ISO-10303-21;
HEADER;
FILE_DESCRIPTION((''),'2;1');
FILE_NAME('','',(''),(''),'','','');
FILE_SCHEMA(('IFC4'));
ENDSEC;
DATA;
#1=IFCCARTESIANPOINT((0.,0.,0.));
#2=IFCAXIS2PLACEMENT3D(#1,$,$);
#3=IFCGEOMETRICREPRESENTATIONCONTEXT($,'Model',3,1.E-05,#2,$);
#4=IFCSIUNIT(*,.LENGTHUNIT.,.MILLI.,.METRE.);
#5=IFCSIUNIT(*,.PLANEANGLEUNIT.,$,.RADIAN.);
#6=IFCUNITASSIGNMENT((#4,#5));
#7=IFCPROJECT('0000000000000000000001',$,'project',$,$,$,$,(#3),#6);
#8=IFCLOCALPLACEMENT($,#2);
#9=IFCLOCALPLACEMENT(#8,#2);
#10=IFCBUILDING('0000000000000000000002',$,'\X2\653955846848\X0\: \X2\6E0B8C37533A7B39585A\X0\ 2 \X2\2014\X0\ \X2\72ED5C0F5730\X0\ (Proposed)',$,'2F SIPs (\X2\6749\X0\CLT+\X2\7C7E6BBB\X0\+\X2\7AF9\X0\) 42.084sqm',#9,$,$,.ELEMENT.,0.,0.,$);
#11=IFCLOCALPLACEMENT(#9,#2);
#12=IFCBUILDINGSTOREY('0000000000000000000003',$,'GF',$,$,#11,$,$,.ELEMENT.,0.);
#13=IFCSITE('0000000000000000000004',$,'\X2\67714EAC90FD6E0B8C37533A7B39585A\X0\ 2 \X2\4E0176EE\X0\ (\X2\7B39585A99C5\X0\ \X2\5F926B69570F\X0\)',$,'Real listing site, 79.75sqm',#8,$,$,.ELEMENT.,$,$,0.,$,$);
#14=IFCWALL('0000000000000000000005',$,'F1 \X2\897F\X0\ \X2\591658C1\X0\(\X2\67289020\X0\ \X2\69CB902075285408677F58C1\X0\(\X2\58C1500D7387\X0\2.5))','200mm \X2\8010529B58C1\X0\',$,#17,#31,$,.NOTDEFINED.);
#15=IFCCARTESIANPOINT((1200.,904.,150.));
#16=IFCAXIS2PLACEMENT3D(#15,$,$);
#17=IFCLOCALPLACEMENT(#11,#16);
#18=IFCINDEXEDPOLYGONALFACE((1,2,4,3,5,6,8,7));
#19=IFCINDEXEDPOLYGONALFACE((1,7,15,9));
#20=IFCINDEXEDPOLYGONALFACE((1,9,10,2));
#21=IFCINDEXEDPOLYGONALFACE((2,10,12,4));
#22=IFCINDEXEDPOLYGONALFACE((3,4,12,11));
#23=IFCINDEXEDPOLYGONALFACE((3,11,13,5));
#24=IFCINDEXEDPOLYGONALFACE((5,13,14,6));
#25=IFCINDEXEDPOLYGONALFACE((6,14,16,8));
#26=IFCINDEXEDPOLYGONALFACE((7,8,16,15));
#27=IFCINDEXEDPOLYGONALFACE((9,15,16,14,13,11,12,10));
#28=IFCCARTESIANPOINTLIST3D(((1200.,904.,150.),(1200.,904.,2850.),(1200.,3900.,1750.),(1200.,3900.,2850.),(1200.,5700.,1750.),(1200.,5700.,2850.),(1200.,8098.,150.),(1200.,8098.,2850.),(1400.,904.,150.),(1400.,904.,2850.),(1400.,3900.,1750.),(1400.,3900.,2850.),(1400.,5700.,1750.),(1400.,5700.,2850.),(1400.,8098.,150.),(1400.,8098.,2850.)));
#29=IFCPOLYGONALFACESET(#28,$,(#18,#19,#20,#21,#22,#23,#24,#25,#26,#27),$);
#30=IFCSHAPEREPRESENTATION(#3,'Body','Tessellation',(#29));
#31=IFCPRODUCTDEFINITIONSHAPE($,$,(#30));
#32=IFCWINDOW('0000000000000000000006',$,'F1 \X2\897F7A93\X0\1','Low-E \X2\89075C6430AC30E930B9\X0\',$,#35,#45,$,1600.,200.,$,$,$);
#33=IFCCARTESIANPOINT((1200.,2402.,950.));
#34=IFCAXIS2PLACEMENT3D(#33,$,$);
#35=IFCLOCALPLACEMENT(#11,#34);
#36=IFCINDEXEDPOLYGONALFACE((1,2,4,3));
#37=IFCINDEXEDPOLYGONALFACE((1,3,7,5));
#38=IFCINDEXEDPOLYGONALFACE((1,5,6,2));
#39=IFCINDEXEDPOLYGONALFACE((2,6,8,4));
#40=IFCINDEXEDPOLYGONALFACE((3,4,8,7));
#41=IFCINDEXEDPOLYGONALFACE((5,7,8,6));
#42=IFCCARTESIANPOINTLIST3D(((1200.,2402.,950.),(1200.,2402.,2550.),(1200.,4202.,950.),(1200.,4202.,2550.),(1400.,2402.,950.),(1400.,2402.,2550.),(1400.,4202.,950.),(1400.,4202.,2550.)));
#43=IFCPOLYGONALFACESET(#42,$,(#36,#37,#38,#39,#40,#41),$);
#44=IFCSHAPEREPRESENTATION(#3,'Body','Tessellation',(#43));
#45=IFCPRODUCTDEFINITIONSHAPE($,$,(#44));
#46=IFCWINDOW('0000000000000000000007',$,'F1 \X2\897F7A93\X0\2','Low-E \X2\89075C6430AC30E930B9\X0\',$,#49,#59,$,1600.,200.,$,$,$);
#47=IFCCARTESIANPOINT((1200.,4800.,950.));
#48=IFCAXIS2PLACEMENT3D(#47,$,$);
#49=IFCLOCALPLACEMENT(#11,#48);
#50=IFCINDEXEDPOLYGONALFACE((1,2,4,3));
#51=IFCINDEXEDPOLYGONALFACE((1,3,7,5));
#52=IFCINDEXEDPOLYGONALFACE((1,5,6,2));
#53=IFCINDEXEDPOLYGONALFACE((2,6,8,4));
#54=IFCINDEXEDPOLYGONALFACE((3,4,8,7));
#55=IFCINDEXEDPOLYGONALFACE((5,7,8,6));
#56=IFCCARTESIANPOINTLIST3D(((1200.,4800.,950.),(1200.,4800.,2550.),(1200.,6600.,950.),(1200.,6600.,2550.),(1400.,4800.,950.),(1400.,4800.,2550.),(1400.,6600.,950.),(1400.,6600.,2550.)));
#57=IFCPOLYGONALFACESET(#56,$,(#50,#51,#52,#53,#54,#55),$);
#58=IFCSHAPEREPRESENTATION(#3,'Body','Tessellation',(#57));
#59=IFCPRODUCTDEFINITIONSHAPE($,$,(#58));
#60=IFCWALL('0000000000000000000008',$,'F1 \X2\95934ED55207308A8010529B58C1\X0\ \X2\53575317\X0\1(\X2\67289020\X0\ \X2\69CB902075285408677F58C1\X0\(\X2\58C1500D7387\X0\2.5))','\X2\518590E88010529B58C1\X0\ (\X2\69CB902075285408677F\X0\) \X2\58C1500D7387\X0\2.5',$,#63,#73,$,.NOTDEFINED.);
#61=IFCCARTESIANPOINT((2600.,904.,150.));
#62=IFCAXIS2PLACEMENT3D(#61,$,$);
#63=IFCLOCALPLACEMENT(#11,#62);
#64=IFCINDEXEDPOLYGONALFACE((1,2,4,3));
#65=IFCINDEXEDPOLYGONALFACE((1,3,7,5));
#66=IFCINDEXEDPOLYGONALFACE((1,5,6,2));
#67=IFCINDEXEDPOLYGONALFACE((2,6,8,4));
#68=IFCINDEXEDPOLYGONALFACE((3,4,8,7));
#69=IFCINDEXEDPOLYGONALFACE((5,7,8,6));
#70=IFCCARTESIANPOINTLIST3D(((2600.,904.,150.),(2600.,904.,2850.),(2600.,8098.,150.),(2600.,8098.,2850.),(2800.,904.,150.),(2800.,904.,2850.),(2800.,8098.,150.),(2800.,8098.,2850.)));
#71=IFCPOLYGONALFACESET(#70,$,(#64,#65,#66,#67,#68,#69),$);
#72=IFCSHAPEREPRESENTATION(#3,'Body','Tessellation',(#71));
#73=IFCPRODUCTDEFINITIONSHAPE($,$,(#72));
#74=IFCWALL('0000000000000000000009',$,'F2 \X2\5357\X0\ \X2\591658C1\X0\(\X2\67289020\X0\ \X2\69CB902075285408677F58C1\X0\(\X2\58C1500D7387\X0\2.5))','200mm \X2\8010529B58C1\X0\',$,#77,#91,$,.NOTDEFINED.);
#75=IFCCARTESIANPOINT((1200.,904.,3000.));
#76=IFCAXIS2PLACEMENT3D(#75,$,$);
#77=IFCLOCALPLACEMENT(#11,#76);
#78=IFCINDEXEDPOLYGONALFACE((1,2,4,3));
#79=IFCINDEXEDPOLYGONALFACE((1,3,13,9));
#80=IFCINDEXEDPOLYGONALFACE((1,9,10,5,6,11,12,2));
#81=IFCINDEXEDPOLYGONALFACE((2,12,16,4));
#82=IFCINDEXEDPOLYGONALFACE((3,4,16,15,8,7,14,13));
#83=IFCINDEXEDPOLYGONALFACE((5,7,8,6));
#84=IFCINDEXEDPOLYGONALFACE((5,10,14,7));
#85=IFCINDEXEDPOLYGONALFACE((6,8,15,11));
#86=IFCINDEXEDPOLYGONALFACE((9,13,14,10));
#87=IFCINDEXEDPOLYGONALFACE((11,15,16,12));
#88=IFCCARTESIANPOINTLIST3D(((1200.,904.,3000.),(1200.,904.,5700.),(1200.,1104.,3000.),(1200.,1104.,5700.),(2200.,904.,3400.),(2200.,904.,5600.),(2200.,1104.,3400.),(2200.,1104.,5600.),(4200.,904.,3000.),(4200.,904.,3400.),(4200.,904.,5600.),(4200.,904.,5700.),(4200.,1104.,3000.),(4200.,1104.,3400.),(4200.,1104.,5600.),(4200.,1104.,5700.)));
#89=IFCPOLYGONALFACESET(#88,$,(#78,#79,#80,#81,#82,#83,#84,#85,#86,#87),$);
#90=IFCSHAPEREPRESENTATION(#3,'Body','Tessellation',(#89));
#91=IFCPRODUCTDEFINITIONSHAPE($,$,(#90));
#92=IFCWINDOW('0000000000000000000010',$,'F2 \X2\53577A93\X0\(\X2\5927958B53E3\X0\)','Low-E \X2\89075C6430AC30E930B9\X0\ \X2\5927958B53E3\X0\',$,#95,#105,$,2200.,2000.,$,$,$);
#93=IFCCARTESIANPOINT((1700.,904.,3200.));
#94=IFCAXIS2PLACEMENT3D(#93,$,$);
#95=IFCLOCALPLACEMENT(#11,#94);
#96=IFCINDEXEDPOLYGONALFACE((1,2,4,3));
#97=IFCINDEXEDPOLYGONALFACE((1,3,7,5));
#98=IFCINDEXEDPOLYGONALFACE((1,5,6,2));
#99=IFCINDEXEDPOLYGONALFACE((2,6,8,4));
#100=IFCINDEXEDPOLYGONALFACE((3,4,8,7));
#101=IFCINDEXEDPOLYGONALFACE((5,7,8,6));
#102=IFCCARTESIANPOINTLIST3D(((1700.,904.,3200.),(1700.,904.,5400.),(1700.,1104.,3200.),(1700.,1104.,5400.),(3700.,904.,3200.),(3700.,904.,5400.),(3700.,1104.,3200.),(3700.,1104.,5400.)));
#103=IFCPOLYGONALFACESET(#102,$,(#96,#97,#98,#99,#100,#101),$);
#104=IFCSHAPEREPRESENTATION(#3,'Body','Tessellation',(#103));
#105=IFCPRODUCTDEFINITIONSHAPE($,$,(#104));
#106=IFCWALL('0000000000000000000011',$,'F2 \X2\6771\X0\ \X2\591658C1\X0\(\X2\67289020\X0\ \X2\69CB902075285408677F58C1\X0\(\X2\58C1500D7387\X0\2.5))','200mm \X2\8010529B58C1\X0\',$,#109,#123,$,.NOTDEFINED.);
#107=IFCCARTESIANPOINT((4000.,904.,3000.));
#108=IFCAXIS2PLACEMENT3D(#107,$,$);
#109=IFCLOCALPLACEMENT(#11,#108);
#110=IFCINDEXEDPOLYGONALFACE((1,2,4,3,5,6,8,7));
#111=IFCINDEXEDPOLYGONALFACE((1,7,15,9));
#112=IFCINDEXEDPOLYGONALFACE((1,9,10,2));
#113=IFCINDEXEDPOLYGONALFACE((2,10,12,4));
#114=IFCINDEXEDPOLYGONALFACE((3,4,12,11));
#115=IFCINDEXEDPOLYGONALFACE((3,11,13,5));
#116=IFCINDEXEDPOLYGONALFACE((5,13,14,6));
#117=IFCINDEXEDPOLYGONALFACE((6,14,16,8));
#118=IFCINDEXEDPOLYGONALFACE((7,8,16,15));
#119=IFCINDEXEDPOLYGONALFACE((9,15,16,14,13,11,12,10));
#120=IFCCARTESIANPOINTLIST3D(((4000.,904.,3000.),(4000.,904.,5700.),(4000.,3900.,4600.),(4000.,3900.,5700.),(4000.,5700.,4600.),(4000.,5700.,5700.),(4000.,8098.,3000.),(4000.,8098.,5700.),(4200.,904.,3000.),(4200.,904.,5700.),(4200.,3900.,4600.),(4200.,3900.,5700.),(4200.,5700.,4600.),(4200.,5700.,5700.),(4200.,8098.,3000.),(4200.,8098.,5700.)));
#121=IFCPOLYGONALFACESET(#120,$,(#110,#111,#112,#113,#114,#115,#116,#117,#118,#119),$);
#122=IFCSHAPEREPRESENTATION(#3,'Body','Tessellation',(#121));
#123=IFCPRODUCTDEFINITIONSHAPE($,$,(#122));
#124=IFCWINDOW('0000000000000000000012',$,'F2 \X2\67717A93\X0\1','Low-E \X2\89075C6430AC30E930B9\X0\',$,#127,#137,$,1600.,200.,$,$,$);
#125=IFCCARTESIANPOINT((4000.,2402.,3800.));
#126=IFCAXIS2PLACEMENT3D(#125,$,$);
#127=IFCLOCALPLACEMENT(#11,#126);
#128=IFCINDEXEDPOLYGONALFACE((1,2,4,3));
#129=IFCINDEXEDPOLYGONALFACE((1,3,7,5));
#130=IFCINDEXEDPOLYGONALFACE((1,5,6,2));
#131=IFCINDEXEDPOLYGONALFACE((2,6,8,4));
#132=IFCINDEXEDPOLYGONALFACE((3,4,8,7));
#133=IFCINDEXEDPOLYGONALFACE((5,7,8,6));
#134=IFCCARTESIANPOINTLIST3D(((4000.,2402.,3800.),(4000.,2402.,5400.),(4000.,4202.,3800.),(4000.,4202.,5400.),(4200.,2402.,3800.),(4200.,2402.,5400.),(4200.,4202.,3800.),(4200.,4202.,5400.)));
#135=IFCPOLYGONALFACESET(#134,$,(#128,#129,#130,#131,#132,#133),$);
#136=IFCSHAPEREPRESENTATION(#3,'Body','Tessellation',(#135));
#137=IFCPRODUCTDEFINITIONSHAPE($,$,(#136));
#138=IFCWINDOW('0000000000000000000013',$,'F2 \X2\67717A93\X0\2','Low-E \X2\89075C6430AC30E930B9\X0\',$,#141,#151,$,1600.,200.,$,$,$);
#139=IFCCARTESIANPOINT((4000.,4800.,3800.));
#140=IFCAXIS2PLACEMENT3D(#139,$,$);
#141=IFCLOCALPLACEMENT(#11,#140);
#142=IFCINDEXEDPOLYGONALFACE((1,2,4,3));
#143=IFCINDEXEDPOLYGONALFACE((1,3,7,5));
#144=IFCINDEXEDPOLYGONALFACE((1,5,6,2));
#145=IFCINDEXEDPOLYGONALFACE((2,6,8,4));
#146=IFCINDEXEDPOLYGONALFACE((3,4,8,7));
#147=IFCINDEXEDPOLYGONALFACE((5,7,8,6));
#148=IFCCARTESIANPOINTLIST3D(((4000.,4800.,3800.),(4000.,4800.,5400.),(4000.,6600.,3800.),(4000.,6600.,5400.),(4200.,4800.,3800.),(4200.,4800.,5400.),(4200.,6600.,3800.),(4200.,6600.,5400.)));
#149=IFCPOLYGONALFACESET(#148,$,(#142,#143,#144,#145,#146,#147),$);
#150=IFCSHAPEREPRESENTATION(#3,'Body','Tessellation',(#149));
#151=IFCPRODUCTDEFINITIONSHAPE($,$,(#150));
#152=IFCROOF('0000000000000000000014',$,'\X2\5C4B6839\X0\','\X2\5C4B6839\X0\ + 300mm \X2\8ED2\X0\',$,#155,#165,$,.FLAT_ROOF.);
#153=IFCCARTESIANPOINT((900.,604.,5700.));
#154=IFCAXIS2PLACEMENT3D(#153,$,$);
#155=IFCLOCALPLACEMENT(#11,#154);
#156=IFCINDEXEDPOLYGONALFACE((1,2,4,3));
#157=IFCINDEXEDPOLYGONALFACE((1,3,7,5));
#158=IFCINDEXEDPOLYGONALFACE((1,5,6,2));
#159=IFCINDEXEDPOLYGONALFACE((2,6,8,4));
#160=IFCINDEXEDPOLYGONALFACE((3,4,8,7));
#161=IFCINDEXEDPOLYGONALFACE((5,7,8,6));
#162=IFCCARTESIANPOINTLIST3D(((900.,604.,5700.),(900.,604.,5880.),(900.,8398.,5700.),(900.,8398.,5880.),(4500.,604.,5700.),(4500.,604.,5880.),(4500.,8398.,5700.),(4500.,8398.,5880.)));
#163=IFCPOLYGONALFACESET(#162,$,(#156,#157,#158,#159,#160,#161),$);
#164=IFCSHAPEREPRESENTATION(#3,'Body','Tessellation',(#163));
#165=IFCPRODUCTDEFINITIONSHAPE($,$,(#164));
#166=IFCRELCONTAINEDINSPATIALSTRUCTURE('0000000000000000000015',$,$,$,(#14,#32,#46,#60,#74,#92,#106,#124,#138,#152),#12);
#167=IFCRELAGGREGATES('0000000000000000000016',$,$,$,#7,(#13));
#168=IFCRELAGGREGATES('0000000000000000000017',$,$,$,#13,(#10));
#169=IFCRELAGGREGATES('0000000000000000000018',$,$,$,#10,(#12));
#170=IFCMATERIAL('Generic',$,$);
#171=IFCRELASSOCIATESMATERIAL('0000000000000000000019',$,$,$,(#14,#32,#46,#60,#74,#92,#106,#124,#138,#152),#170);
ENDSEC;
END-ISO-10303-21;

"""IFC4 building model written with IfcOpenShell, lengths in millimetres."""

from ifc_helpers import new_model, si_unit, frame, frame_2d, origin, place, context, project, spatial, rectangle, extrude, material, element, fill, save


model = new_model("IFC4")

# Units and contexts
model_context = context("Model", 3, precision=1e-05, world=origin())
ifc_project = project(units=[si_unit("LENGTHUNIT", "METRE", prefix="MILLI"), si_unit("PLANEANGLEUNIT", "RADIAN")], contexts=[model_context])

# Site, building, storey
site_placement = place(None, origin())
site = spatial("IfcSite", under=ifc_project, at=site_placement, Name="東京都渋谷区笹塚 2 丁目 (笹塚駅 徒歩圏)", ObjectType="Real listing site, 79.75sqm", CompositionType="ELEMENT", RefElevation=0.0)
building_placement = place(site_placement, origin())
building = spatial("IfcBuilding", under=site, at=building_placement, Name="改善案: 渋谷区笹塚 2 — 狭小地 (Proposed)", ObjectType="2F SIPs (杉CLT+籾殻+竹) 42.084sqm", CompositionType="ELEMENT", ElevationOfRefHeight=0.0, ElevationOfTerrain=0.0)
storey_placement = place(building_placement, origin())
storey = spatial("IfcBuildingStorey", under=building, at=storey_placement, Name="GF", CompositionType="ELEMENT", Elevation=0.0)

# Shared definitions
ifc_material_1 = material(Name="Generic")

# Wall, openings, windows
wall_1_placement = place(storey_placement, frame((1200.0, 904.0, 150.0)))
wall_1 = element("IfcWall", 1, at=wall_1_placement, inside=storey, material=ifc_material_1, Name="F1 西 外壁(木造 構造用合板壁(壁倍率2.5))", Description="200mm 耐力壁", PredefinedType="NOTDEFINED", context=model_context, shape_type="SweptSolid", body=[
    extrude(rectangle(XDim=200.0, YDim=7194.0, at=frame_2d((100.0, 3597.0))), frame((1200.0, 904.0, 150.0)), (0.0, 0.0, 1.0), 2700.0),
])
opening_1_placement = place(storey_placement, frame((1200.0, 2402.0, 950.0)))
opening_1 = element("IfcOpeningElement", 2, at=opening_1_placement, cuts=wall_1, PredefinedType="NOTDEFINED", context=model_context, shape_type="SweptSolid", body=[
    extrude(rectangle(XDim=200.0, YDim=1800.0, at=frame_2d((100.0, 900.0))), frame((1200.0, 2402.0, 950.0)), (0.0, 0.0, 1.0), 1600.0),
])
opening_2_placement = place(storey_placement, frame((1200.0, 4800.0, 950.0)))
opening_2 = element("IfcOpeningElement", 3, at=opening_2_placement, cuts=wall_1, PredefinedType="NOTDEFINED", context=model_context, shape_type="SweptSolid", body=[
    extrude(rectangle(XDim=200.0, YDim=1800.0, at=frame_2d((100.0, 900.0))), frame((1200.0, 4800.0, 950.0)), (0.0, 0.0, 1.0), 1600.0),
])
window_1_placement = place(storey_placement, frame((1200.0, 2402.0, 950.0)))
window_1 = element("IfcWindow", 4, at=window_1_placement, inside=storey, material=ifc_material_1, Name="F1 西窓1", Description="Low-E 複層ガラス", OverallHeight=1600.0, OverallWidth=200.0, context=model_context, shape_type="SweptSolid", body=[
    extrude(rectangle(XDim=200.0, YDim=1800.0, at=frame_2d((100.0, 900.0))), frame((1200.0, 2402.0, 950.0)), (0.0, 0.0, 1.0), 1600.0),
])
fill(opening_1, window_1)
window_2_placement = place(storey_placement, frame((1200.0, 4800.0, 950.0)))
window_2 = element("IfcWindow", 5, at=window_2_placement, inside=storey, material=ifc_material_1, Name="F1 西窓2", Description="Low-E 複層ガラス", OverallHeight=1600.0, OverallWidth=200.0, context=model_context, shape_type="SweptSolid", body=[
    extrude(rectangle(XDim=200.0, YDim=1800.0, at=frame_2d((100.0, 900.0))), frame((1200.0, 4800.0, 950.0)), (0.0, 0.0, 1.0), 1600.0),
])
fill(opening_2, window_2)

# Wall
wall_2_placement = place(storey_placement, frame((2600.0, 904.0, 150.0)))
element("IfcWall", 6, at=wall_2_placement, inside=storey, material=ifc_material_1, Name="F1 間仕切り耐力壁 南北1(木造 構造用合板壁(壁倍率2.5))", Description="内部耐力壁 (構造用合板) 壁倍率2.5", PredefinedType="NOTDEFINED", context=model_context, shape_type="SweptSolid", body=[
    extrude(rectangle(XDim=200.0, YDim=7194.0, at=frame_2d((100.0, 3597.0))), frame((2600.0, 904.0, 150.0)), (0.0, 0.0, 1.0), 2700.0),
])

# Wall, opening, window
wall_3_placement = place(storey_placement, frame((1200.0, 904.0, 3000.0)))
wall_3 = element("IfcWall", 7, at=wall_3_placement, inside=storey, material=ifc_material_1, Name="F2 南 外壁(木造 構造用合板壁(壁倍率2.5))", Description="200mm 耐力壁", PredefinedType="NOTDEFINED", context=model_context, shape_type="SweptSolid", body=[
    extrude(rectangle(XDim=3000.0, YDim=200.0, at=frame_2d((1500.0, 100.0))), frame((1200.0, 904.0, 3000.0)), (0.0, 0.0, 1.0), 2700.0),
])
opening_3_placement = place(storey_placement, frame((1700.0, 904.0, 3200.0)))
opening_3 = element("IfcOpeningElement", 8, at=opening_3_placement, cuts=wall_3, PredefinedType="NOTDEFINED", context=model_context, shape_type="SweptSolid", body=[
    extrude(rectangle(XDim=2000.0, YDim=200.0, at=frame_2d((1000.0, 100.0))), frame((1700.0, 904.0, 3200.0)), (0.0, 0.0, 1.0), 2200.0),
])
window_3_placement = place(storey_placement, frame((1700.0, 904.0, 3200.0)))
window_3 = element("IfcWindow", 9, at=window_3_placement, inside=storey, material=ifc_material_1, Name="F2 南窓(大開口)", Description="Low-E 複層ガラス 大開口", OverallHeight=2200.0, OverallWidth=2000.0, context=model_context, shape_type="SweptSolid", body=[
    extrude(rectangle(XDim=2000.0, YDim=200.0, at=frame_2d((1000.0, 100.0))), frame((1700.0, 904.0, 3200.0)), (0.0, 0.0, 1.0), 2200.0),
])
fill(opening_3, window_3)

# Wall, openings, windows
wall_4_placement = place(storey_placement, frame((4000.0, 904.0, 3000.0)))
wall_4 = element("IfcWall", 10, at=wall_4_placement, inside=storey, material=ifc_material_1, Name="F2 東 外壁(木造 構造用合板壁(壁倍率2.5))", Description="200mm 耐力壁", PredefinedType="NOTDEFINED", context=model_context, shape_type="SweptSolid", body=[
    extrude(rectangle(XDim=200.0, YDim=7194.0, at=frame_2d((100.0, 3597.0))), frame((4000.0, 904.0, 3000.0)), (0.0, 0.0, 1.0), 2700.0),
])
opening_4_placement = place(storey_placement, frame((4000.0, 2402.0, 3800.0)))
opening_4 = element("IfcOpeningElement", 11, at=opening_4_placement, cuts=wall_4, PredefinedType="NOTDEFINED", context=model_context, shape_type="SweptSolid", body=[
    extrude(rectangle(XDim=200.0, YDim=1800.0, at=frame_2d((100.0, 900.0))), frame((4000.0, 2402.0, 3800.0)), (0.0, 0.0, 1.0), 1600.0),
])
opening_5_placement = place(storey_placement, frame((4000.0, 4800.0, 3800.0)))
opening_5 = element("IfcOpeningElement", 12, at=opening_5_placement, cuts=wall_4, PredefinedType="NOTDEFINED", context=model_context, shape_type="SweptSolid", body=[
    extrude(rectangle(XDim=200.0, YDim=1800.0, at=frame_2d((100.0, 900.0))), frame((4000.0, 4800.0, 3800.0)), (0.0, 0.0, 1.0), 1600.0),
])
window_4_placement = place(storey_placement, frame((4000.0, 2402.0, 3800.0)))
window_4 = element("IfcWindow", 13, at=window_4_placement, inside=storey, material=ifc_material_1, Name="F2 東窓1", Description="Low-E 複層ガラス", OverallHeight=1600.0, OverallWidth=200.0, context=model_context, shape_type="SweptSolid", body=[
    extrude(rectangle(XDim=200.0, YDim=1800.0, at=frame_2d((100.0, 900.0))), frame((4000.0, 2402.0, 3800.0)), (0.0, 0.0, 1.0), 1600.0),
])
fill(opening_4, window_4)
window_5_placement = place(storey_placement, frame((4000.0, 4800.0, 3800.0)))
window_5 = element("IfcWindow", 14, at=window_5_placement, inside=storey, material=ifc_material_1, Name="F2 東窓2", Description="Low-E 複層ガラス", OverallHeight=1600.0, OverallWidth=200.0, context=model_context, shape_type="SweptSolid", body=[
    extrude(rectangle(XDim=200.0, YDim=1800.0, at=frame_2d((100.0, 900.0))), frame((4000.0, 4800.0, 3800.0)), (0.0, 0.0, 1.0), 1600.0),
])
fill(opening_5, window_5)

# Roof
roof_placement = place(storey_placement, frame((900.0, 604.0, 5700.0)))
element("IfcRoof", 15, at=roof_placement, inside=storey, material=ifc_material_1, Name="屋根", Description="屋根 + 300mm 軒", PredefinedType="FLAT_ROOF", context=model_context, shape_type="SweptSolid", body=[
    extrude(rectangle(XDim=3600.0, YDim=7794.0, at=frame_2d((1800.0, 3897.0))), frame((900.0, 604.0, 5700.0)), (0.0, 0.0, 1.0), 180.0),
])

save(model, "model.ifc")
